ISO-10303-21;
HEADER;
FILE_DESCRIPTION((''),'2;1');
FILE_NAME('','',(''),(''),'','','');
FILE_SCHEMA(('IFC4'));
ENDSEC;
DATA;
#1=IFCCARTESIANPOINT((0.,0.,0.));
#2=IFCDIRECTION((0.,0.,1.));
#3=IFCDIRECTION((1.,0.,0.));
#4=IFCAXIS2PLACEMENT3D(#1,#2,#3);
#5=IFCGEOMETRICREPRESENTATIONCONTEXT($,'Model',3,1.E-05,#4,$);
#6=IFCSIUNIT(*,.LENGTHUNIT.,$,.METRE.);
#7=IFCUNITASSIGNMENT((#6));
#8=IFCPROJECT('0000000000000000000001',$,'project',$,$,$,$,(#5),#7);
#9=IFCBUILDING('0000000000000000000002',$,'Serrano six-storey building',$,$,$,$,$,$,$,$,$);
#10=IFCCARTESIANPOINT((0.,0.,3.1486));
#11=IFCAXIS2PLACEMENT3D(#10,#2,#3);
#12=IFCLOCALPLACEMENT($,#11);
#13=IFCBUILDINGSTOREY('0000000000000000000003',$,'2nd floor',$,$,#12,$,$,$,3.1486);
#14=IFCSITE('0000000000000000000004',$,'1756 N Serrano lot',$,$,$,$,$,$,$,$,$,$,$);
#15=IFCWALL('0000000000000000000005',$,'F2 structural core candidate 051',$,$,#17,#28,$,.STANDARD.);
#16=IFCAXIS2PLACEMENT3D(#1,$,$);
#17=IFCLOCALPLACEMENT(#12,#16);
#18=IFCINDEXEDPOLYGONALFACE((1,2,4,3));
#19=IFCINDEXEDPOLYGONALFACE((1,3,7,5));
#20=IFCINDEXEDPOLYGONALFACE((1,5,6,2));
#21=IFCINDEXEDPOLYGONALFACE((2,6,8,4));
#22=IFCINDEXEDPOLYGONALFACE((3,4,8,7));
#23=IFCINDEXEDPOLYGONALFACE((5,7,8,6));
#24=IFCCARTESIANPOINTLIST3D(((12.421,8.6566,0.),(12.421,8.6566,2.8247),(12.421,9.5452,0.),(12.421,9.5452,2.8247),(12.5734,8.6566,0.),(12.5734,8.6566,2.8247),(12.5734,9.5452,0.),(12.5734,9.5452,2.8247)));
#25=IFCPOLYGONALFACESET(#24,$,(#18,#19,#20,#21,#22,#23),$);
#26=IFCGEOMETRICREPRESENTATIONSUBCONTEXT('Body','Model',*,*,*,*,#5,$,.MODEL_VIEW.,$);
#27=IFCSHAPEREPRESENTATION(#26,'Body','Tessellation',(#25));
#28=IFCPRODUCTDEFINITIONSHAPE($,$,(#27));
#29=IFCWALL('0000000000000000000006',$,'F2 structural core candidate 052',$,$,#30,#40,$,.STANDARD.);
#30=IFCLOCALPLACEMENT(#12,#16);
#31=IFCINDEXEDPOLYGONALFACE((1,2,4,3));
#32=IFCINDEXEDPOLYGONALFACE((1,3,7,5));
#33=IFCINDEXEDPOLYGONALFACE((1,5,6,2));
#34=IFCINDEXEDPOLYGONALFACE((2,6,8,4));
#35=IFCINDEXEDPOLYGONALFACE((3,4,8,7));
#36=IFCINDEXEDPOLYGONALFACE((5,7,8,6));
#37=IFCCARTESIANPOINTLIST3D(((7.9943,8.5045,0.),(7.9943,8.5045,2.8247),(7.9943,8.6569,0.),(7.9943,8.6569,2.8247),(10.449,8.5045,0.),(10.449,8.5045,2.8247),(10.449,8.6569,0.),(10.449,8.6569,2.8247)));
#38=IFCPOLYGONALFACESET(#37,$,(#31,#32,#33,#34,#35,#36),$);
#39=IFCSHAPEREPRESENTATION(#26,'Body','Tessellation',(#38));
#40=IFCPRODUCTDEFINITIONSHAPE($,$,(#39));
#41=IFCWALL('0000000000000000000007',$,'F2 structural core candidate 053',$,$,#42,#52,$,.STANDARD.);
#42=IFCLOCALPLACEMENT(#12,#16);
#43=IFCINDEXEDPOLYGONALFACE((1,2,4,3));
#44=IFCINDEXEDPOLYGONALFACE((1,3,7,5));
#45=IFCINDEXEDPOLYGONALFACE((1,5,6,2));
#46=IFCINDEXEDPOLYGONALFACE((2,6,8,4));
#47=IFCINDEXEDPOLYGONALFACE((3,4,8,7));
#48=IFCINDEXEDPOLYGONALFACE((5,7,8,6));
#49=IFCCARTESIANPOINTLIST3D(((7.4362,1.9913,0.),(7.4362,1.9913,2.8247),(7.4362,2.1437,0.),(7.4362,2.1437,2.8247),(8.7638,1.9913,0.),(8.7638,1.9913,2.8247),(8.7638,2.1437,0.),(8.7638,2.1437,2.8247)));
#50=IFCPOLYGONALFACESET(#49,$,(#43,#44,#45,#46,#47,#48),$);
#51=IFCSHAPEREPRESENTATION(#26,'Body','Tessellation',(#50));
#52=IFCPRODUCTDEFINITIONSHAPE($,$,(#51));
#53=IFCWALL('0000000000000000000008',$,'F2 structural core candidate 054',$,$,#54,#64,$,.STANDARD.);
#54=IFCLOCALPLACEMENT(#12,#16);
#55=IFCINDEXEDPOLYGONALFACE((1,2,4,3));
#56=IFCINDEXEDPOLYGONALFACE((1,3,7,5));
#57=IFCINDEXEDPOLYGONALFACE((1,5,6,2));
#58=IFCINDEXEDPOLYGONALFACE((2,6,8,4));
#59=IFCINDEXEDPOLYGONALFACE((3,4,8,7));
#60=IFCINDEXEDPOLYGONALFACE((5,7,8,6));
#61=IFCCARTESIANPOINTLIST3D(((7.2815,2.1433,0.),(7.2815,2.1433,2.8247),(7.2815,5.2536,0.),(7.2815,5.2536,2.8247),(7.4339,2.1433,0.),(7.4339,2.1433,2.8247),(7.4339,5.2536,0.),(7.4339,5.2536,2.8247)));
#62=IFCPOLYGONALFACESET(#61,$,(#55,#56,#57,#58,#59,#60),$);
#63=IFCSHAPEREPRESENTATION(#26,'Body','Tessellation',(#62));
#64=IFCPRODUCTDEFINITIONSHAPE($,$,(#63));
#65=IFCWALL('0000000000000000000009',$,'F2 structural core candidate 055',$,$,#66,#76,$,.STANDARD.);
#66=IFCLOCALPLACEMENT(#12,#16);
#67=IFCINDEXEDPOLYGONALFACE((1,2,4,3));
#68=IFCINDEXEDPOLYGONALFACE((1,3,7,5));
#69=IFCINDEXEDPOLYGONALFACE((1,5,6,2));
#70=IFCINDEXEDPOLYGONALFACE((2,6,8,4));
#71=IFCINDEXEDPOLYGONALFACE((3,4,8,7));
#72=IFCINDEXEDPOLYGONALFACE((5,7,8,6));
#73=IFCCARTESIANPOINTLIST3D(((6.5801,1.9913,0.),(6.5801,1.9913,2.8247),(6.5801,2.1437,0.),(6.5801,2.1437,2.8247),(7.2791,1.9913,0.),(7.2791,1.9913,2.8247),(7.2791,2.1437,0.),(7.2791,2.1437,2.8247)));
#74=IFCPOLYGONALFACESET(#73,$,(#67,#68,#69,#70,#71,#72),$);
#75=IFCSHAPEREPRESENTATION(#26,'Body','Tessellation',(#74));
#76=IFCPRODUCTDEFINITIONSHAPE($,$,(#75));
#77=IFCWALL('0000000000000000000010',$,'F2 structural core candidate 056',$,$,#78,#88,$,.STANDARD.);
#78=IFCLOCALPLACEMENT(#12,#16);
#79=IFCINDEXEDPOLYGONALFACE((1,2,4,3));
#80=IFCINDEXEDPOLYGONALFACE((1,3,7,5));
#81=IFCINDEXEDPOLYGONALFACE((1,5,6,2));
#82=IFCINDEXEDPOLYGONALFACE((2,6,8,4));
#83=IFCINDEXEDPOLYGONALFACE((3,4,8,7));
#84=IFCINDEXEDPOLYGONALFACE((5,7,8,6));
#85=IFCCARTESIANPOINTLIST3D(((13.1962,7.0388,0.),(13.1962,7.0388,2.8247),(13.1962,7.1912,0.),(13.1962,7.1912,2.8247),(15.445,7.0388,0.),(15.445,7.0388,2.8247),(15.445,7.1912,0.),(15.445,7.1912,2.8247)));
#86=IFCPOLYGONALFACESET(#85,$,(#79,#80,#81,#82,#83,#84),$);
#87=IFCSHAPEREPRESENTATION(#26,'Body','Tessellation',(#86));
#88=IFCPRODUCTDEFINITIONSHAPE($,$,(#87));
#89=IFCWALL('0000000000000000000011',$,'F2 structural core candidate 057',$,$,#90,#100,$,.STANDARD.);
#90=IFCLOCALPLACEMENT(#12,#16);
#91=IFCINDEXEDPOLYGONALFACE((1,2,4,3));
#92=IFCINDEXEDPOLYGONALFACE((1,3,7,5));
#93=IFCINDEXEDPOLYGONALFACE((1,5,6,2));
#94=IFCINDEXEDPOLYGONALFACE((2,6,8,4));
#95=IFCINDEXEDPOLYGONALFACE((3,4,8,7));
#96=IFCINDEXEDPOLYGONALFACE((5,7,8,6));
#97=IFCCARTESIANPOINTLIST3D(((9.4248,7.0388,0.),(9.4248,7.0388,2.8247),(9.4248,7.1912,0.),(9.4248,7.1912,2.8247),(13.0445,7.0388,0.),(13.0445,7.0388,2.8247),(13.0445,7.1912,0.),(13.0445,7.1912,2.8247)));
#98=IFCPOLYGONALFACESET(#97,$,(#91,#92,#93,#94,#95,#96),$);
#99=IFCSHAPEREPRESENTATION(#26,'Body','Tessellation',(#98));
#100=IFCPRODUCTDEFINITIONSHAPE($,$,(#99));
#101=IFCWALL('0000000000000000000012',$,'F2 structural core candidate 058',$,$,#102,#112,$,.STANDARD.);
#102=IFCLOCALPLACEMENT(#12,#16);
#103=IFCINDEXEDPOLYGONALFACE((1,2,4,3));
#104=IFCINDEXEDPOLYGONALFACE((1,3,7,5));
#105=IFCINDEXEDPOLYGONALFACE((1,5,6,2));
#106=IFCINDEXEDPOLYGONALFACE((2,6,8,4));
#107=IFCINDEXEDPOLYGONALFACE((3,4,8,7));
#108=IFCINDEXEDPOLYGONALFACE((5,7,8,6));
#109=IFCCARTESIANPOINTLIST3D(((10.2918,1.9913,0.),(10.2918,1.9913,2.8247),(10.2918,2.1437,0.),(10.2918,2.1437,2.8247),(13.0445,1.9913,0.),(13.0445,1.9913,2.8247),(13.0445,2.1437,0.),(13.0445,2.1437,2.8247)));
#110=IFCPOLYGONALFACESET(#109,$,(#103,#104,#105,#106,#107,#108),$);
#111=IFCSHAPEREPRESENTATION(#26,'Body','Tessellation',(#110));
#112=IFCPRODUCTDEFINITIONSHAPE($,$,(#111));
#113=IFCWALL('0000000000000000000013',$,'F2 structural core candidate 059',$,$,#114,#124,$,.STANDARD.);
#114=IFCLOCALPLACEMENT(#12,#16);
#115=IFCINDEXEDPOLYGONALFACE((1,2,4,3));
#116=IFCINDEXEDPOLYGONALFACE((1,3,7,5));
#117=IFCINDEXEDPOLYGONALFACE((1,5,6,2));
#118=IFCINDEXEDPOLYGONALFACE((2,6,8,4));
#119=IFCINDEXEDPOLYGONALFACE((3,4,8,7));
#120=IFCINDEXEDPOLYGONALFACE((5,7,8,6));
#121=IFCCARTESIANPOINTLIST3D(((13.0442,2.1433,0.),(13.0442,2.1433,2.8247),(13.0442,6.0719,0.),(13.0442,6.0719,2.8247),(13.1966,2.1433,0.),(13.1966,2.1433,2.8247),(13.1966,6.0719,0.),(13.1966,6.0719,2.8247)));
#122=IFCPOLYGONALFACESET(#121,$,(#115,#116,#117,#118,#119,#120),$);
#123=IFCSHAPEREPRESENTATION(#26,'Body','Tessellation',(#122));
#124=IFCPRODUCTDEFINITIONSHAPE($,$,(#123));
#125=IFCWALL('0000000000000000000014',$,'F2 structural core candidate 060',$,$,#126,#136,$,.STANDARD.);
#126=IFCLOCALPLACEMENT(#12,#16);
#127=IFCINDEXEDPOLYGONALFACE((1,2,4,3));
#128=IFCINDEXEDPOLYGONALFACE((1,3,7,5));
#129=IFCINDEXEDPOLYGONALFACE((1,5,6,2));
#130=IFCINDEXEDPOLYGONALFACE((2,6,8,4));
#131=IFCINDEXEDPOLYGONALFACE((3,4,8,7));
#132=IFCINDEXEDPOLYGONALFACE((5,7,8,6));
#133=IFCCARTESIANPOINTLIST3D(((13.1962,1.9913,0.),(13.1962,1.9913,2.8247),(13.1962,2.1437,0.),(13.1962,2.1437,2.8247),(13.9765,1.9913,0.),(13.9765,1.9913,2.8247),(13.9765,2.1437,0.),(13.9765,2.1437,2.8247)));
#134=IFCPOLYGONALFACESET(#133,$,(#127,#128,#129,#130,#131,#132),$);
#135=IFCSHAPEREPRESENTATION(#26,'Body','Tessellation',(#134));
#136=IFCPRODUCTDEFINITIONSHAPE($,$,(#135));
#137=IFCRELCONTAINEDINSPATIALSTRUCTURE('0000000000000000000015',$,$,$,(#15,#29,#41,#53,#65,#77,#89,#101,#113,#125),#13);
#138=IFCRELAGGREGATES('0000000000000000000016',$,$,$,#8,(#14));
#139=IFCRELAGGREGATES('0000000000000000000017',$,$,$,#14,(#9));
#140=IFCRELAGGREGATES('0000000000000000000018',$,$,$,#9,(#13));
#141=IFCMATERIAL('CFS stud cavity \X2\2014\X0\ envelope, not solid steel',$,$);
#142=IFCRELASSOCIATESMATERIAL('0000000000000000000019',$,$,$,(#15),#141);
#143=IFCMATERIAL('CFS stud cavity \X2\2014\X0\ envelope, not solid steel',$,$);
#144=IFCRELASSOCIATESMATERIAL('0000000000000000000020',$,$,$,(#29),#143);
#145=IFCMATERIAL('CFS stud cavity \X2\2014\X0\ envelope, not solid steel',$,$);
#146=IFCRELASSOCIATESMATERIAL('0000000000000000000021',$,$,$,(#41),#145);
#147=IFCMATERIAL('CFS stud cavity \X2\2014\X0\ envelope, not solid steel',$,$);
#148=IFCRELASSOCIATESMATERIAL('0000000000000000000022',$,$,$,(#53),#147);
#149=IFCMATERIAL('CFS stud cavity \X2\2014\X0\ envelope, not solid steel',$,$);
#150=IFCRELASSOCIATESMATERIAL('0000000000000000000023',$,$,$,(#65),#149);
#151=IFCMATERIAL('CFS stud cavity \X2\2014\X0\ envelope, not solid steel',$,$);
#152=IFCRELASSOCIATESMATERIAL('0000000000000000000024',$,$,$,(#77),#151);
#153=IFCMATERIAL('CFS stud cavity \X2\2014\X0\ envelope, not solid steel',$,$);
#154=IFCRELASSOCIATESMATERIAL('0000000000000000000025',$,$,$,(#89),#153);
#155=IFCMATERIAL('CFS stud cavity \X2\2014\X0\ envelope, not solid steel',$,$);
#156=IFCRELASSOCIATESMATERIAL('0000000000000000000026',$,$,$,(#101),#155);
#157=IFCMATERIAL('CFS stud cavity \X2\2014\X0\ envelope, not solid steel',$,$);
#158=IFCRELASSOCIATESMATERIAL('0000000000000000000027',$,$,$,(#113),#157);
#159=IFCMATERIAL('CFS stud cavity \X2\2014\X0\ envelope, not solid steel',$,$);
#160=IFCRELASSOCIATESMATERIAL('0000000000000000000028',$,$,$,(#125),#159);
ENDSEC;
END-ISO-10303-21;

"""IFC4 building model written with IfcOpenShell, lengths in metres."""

from ifc_helpers import new_model, si_unit, frame, origin_with_axes, place, context, subcontext, project, spatial, polyline, outline, extrude, material, element, save


model = new_model("IFC4")

# Units and contexts
model_context = context("Model", 3, precision=1e-05, world=origin_with_axes())
body_context = subcontext(model_context, "Body", "Model", "MODEL_VIEW")
ifc_project = project(units=[si_unit("LENGTHUNIT", "METRE")], contexts=[model_context])

# Site, building, storey
site = spatial("IfcSite", under=ifc_project, Name="1756 N Serrano lot")
building = spatial("IfcBuilding", under=site, Name="Serrano six-storey building")
storey_placement = place(None, frame((0.0, 0.0, 3.1486), z_axis=(0.0, 0.0, 1.0), x_axis=(1.0, 0.0, 0.0)))
storey = spatial("IfcBuildingStorey", under=building, at=storey_placement, Name="2nd floor", Elevation=3.1486)

# Walls
ifc_material_1 = material(Name="CFS stud cavity — envelope, not solid steel")
wall_1_placement = place(storey_placement, frame((0.0, 0.0, -3.1486), z_axis=(0.0, 0.0, 1.0), x_axis=(1.0, 0.0, 0.0)))
element("IfcWall", 1, at=wall_1_placement, inside=storey, material=ifc_material_1, Name="F2 structural core candidate 051", PredefinedType="STANDARD", context=body_context, shape_type="SweptSolid", body=[
    extrude(outline(polyline([(12.5734, 8.6566), (12.421, 8.6566), (12.421, 9.5452), (12.5734, 9.5452), (12.5734, 8.6566)])), frame((0.0, 0.0, 3.1486)), (0.0, 0.0, 1.0), 2.8247),
])
ifc_material_2 = material(Name="CFS stud cavity — envelope, not solid steel")
wall_2_placement = place(storey_placement, frame((0.0, 0.0, -3.1486), z_axis=(0.0, 0.0, 1.0), x_axis=(1.0, 0.0, 0.0)))
element("IfcWall", 2, at=wall_2_placement, inside=storey, material=ifc_material_2, Name="F2 structural core candidate 052", PredefinedType="STANDARD", context=body_context, shape_type="SweptSolid", body=[
    extrude(outline(polyline([(10.449, 8.6569), (10.449, 8.5045), (7.9943, 8.5045), (7.9943, 8.6569), (10.449, 8.6569)])), frame((0.0, 0.0, 3.1486)), (0.0, 0.0, 1.0), 2.8247),
])
ifc_material_3 = material(Name="CFS stud cavity — envelope, not solid steel")
wall_3_placement = place(storey_placement, frame((0.0, 0.0, -3.1486), z_axis=(0.0, 0.0, 1.0), x_axis=(1.0, 0.0, 0.0)))
element("IfcWall", 3, at=wall_3_placement, inside=storey, material=ifc_material_3, Name="F2 structural core candidate 053", PredefinedType="STANDARD", context=body_context, shape_type="SweptSolid", body=[
    extrude(outline(polyline([(8.7638, 2.1437), (8.7638, 1.9913), (7.4362, 1.9913), (7.4362, 2.1437), (8.7638, 2.1437)])), frame((0.0, 0.0, 3.1486)), (0.0, 0.0, 1.0), 2.8247),
])
ifc_material_4 = material(Name="CFS stud cavity — envelope, not solid steel")
wall_4_placement = place(storey_placement, frame((0.0, 0.0, -3.1486), z_axis=(0.0, 0.0, 1.0), x_axis=(1.0, 0.0, 0.0)))
element("IfcWall", 4, at=wall_4_placement, inside=storey, material=ifc_material_4, Name="F2 structural core candidate 054", PredefinedType="STANDARD", context=body_context, shape_type="SweptSolid", body=[
    extrude(outline(polyline([(7.4339, 2.1433), (7.2815, 2.1433), (7.2815, 5.2536), (7.4339, 5.2536), (7.4339, 2.1433)])), frame((0.0, 0.0, 3.1486)), (0.0, 0.0, 1.0), 2.8247),
])
ifc_material_5 = material(Name="CFS stud cavity — envelope, not solid steel")
wall_5_placement = place(storey_placement, frame((0.0, 0.0, -3.1486), z_axis=(0.0, 0.0, 1.0), x_axis=(1.0, 0.0, 0.0)))
element("IfcWall", 5, at=wall_5_placement, inside=storey, material=ifc_material_5, Name="F2 structural core candidate 055", PredefinedType="STANDARD", context=body_context, shape_type="SweptSolid", body=[
    extrude(outline(polyline([(7.2791, 2.1437), (7.2791, 1.9913), (6.5801, 1.9913), (6.5801, 2.1437), (7.2791, 2.1437)])), frame((0.0, 0.0, 3.1486)), (0.0, 0.0, 1.0), 2.8247),
])
ifc_material_6 = material(Name="CFS stud cavity — envelope, not solid steel")
wall_6_placement = place(storey_placement, frame((0.0, 0.0, -3.1486), z_axis=(0.0, 0.0, 1.0), x_axis=(1.0, 0.0, 0.0)))
element("IfcWall", 6, at=wall_6_placement, inside=storey, material=ifc_material_6, Name="F2 structural core candidate 056", PredefinedType="STANDARD", context=body_context, shape_type="SweptSolid", body=[
    extrude(outline(polyline([(15.445, 7.1912), (15.445, 7.0388), (13.1962, 7.0388), (13.1962, 7.1912), (15.445, 7.1912)])), frame((0.0, 0.0, 3.1486)), (0.0, 0.0, 1.0), 2.8247),
])
ifc_material_7 = material(Name="CFS stud cavity — envelope, not solid steel")
wall_7_placement = place(storey_placement, frame((0.0, 0.0, -3.1486), z_axis=(0.0, 0.0, 1.0), x_axis=(1.0, 0.0, 0.0)))
element("IfcWall", 7, at=wall_7_placement, inside=storey, material=ifc_material_7, Name="F2 structural core candidate 057", PredefinedType="STANDARD", context=body_context, shape_type="SweptSolid", body=[
    extrude(outline(polyline([(13.0445, 7.1912), (13.0445, 7.0388), (9.4248, 7.0388), (9.4248, 7.1912), (13.0445, 7.1912)])), frame((0.0, 0.0, 3.1486)), (0.0, 0.0, 1.0), 2.8247),
])
ifc_material_8 = material(Name="CFS stud cavity — envelope, not solid steel")
wall_8_placement = place(storey_placement, frame((0.0, 0.0, -3.1486), z_axis=(0.0, 0.0, 1.0), x_axis=(1.0, 0.0, 0.0)))
element("IfcWall", 8, at=wall_8_placement, inside=storey, material=ifc_material_8, Name="F2 structural core candidate 058", PredefinedType="STANDARD", context=body_context, shape_type="SweptSolid", body=[
    extrude(outline(polyline([(13.0445, 2.1437), (13.0445, 1.9913), (10.2918, 1.9913), (10.2918, 2.1437), (13.0445, 2.1437)])), frame((0.0, 0.0, 3.1486)), (0.0, 0.0, 1.0), 2.8247),
])
ifc_material_9 = material(Name="CFS stud cavity — envelope, not solid steel")
wall_9_placement = place(storey_placement, frame((0.0, 0.0, -3.1486), z_axis=(0.0, 0.0, 1.0), x_axis=(1.0, 0.0, 0.0)))
element("IfcWall", 9, at=wall_9_placement, inside=storey, material=ifc_material_9, Name="F2 structural core candidate 059", PredefinedType="STANDARD", context=body_context, shape_type="SweptSolid", body=[
    extrude(outline(polyline([(13.1966, 2.1433), (13.0442, 2.1433), (13.0442, 6.0719), (13.1966, 6.0719), (13.1966, 2.1433)])), frame((0.0, 0.0, 3.1486)), (0.0, 0.0, 1.0), 2.8247),
])
ifc_material_10 = material(Name="CFS stud cavity — envelope, not solid steel")
wall_10_placement = place(storey_placement, frame((0.0, 0.0, -3.1486), z_axis=(0.0, 0.0, 1.0), x_axis=(1.0, 0.0, 0.0)))
element("IfcWall", 10, at=wall_10_placement, inside=storey, material=ifc_material_10, Name="F2 structural core candidate 060", PredefinedType="STANDARD", context=body_context, shape_type="SweptSolid", body=[
    extrude(outline(polyline([(13.9765, 2.1437), (13.9765, 1.9913), (13.1962, 1.9913), (13.1962, 2.1437), (13.9765, 2.1437)])), frame((0.0, 0.0, 3.1486)), (0.0, 0.0, 1.0), 2.8247),
])

save(model, "model.ifc")
